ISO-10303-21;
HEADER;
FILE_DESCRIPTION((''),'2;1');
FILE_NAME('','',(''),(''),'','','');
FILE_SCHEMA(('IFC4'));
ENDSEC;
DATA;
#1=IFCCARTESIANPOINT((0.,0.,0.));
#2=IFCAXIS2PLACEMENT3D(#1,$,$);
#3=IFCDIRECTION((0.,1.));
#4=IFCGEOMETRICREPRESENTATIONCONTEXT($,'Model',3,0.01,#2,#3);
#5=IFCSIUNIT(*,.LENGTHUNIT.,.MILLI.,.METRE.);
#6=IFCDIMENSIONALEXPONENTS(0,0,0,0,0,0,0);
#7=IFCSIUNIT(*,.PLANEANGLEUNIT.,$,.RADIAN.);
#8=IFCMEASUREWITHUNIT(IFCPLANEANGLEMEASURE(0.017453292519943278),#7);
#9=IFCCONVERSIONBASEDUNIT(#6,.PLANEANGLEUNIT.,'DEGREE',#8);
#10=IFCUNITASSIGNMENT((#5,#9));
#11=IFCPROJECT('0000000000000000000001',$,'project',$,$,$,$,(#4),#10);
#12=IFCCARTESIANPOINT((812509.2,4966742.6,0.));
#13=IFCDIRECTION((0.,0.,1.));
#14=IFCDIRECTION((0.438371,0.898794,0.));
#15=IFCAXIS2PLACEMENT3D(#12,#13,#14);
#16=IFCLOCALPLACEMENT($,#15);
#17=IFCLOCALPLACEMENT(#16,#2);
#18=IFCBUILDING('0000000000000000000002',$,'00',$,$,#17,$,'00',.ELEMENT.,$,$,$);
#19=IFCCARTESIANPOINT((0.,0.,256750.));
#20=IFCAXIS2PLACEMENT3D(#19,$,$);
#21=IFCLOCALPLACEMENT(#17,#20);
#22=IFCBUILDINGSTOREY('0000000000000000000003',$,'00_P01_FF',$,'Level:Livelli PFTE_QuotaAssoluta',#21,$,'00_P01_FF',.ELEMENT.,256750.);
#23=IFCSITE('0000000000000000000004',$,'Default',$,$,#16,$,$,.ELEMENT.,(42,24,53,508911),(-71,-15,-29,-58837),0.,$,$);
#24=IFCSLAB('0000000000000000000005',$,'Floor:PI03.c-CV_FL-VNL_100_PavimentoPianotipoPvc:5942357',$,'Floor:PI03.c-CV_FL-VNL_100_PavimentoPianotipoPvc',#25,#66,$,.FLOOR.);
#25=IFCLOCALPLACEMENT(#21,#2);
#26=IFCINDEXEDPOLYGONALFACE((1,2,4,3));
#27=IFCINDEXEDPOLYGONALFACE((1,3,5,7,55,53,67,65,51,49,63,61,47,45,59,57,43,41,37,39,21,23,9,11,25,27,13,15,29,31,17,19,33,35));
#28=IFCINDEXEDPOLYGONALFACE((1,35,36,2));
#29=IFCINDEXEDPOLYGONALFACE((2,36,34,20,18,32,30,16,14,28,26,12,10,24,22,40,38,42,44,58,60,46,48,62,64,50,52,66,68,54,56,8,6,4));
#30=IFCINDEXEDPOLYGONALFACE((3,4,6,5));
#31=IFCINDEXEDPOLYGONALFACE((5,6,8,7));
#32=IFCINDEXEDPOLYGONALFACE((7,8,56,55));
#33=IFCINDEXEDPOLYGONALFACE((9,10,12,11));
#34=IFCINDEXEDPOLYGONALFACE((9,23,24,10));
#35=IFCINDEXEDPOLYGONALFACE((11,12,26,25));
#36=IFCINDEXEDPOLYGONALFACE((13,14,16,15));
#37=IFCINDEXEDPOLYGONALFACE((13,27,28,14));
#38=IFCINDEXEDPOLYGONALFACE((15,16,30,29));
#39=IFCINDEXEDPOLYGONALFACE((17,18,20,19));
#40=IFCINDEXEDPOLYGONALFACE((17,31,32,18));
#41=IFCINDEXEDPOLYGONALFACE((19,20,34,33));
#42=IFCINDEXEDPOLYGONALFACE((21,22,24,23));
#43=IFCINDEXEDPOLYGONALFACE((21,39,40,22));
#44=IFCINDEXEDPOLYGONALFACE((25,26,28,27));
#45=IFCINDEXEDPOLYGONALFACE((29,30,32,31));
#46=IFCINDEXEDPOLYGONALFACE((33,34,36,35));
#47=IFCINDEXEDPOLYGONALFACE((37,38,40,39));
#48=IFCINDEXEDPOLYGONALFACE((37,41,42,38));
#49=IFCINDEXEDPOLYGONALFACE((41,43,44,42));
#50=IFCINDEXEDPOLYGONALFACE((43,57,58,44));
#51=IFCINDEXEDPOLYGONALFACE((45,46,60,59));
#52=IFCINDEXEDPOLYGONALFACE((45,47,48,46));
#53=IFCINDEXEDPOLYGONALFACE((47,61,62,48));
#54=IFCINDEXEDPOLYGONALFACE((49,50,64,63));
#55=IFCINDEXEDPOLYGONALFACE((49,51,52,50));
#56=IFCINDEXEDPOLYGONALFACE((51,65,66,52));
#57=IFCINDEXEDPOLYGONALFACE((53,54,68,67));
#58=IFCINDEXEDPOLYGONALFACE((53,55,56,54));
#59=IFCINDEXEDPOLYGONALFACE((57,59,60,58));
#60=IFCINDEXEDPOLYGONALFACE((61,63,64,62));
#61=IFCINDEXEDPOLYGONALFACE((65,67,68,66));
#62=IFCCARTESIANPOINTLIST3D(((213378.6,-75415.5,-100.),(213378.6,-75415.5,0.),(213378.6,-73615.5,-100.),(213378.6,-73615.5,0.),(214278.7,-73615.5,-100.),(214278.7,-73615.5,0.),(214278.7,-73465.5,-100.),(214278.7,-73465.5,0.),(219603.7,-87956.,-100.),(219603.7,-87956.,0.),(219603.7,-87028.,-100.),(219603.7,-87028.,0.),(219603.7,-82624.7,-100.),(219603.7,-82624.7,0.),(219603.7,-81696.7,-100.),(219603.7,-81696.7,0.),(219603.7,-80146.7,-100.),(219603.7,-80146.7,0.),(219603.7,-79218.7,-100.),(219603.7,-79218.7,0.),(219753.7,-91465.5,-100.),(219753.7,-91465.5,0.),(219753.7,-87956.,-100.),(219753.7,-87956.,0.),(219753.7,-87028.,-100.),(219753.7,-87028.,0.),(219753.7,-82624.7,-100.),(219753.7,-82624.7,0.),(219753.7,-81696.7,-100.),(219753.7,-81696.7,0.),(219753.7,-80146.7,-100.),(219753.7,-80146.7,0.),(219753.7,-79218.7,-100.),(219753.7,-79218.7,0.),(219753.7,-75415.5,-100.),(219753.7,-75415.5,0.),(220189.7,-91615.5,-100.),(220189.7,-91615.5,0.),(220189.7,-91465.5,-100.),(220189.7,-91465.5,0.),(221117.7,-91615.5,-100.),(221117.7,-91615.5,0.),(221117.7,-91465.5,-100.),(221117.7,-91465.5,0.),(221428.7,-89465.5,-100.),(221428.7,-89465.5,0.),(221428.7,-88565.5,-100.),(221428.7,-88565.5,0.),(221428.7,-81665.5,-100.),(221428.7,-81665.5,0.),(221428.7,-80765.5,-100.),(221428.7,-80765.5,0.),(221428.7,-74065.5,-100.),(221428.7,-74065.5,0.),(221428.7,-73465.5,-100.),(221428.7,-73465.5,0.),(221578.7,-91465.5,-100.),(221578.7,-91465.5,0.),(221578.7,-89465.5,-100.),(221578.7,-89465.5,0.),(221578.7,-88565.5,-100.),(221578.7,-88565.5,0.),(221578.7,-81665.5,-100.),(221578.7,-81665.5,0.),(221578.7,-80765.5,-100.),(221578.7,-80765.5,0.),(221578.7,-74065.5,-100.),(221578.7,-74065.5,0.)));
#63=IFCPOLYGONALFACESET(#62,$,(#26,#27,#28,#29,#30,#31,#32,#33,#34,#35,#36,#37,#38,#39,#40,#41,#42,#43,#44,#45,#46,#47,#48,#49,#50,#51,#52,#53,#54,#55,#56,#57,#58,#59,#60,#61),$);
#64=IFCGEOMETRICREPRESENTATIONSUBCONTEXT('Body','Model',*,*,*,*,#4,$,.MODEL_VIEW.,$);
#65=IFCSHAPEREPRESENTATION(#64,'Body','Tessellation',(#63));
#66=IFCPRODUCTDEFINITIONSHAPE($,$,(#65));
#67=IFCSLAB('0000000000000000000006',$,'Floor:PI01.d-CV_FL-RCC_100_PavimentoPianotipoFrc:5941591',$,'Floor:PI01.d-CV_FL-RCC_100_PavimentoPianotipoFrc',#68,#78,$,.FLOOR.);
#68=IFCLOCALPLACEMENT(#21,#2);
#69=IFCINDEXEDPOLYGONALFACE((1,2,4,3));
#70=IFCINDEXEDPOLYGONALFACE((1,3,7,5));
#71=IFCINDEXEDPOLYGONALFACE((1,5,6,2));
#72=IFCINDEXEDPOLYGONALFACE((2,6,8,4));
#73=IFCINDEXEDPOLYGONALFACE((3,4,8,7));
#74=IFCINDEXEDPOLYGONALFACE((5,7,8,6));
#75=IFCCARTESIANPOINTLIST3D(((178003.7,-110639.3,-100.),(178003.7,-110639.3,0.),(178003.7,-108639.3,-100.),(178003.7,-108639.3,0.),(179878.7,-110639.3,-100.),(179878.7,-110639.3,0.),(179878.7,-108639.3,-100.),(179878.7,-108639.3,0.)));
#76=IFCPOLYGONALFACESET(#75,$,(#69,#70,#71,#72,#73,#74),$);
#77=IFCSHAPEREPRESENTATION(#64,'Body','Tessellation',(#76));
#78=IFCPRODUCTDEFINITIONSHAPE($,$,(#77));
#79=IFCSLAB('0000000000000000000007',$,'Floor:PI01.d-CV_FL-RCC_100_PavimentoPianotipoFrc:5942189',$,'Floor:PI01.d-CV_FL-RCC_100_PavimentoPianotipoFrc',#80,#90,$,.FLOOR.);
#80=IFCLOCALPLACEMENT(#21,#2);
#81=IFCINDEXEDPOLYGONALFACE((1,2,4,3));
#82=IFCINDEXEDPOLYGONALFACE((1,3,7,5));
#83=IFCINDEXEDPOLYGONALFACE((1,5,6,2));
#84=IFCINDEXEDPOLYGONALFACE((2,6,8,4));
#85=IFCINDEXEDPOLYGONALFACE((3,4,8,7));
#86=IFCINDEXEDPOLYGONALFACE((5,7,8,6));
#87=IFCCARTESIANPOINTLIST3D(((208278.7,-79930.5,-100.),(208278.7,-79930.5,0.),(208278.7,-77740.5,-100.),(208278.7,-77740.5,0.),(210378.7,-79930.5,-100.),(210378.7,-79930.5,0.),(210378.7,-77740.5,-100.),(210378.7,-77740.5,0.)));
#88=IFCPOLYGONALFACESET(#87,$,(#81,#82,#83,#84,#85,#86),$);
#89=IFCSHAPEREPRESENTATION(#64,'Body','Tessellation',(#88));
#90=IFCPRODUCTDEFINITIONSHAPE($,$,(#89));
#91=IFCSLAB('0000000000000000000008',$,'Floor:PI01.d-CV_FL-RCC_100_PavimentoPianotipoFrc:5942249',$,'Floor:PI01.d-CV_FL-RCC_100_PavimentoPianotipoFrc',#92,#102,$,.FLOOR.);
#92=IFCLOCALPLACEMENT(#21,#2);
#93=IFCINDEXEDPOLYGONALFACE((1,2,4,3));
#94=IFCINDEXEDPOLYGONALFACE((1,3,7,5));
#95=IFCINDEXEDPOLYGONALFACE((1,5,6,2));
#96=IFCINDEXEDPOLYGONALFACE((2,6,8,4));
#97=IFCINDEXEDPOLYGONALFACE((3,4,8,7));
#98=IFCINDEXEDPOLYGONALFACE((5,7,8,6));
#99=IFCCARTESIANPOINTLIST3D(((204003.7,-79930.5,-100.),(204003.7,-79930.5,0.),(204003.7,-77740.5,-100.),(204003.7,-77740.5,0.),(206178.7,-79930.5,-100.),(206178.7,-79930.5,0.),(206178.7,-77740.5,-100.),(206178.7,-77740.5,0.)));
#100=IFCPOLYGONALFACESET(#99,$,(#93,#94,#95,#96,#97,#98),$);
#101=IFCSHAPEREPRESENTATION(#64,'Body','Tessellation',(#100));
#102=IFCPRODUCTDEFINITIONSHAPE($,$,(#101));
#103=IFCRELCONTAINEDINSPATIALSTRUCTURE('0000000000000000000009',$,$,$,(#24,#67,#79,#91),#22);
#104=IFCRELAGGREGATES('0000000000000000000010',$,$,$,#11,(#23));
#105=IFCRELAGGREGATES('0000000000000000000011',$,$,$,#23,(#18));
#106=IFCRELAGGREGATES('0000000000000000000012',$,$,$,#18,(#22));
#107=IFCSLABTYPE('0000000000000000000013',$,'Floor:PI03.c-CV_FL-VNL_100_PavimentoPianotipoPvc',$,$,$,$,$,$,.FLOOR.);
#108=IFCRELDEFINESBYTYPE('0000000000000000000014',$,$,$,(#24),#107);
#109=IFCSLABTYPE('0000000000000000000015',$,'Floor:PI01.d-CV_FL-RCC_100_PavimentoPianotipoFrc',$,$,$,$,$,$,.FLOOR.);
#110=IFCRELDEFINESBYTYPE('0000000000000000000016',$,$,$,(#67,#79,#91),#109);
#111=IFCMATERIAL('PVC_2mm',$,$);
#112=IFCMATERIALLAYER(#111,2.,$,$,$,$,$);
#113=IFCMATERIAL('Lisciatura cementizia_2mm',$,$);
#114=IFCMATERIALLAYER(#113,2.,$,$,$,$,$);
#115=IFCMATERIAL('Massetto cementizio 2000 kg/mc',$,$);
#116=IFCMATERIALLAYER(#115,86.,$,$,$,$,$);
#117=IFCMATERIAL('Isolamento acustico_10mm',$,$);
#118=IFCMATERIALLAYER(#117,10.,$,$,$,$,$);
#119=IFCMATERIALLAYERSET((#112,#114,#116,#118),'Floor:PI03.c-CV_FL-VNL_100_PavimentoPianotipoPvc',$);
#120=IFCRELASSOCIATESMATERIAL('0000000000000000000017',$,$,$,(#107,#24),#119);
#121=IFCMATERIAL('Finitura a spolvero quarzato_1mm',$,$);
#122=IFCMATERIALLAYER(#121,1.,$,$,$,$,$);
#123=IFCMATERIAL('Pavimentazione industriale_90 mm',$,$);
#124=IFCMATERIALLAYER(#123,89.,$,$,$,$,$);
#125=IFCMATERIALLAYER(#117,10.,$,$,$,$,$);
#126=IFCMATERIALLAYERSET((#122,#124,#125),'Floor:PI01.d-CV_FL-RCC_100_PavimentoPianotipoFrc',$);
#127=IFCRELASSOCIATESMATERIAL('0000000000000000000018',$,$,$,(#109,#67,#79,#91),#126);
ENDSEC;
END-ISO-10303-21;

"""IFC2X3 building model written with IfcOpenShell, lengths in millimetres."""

from ifc_helpers import new_model, entity, si_unit, converted_unit, direction, frame, frame_2d, origin, place, context, subcontext, project, spatial, polyline, rectangle, outline, extrude, material, layer, layer_set, layer_usage, type_object, element, save


model = new_model("IFC2X3")

# Units and contexts
model_context = context("Model", 3, precision=0.01, world=origin(), true_north=direction((0.0, 1.0)))
body_context = subcontext(model_context, "Body", "Model", "MODEL_VIEW")
ifc_project = project(units=[si_unit("LENGTHUNIT", "METRE", prefix="MILLI"), converted_unit("PLANEANGLEUNIT", "DEGREE", entity("IfcPlaneAngleMeasure", 0.017453292519943278), si_unit("PLANEANGLEUNIT", "RADIAN"), dimensions=[0, 0, 0, 0, 0, 0, 0])], contexts=[model_context])

# Site, building, storey
site_placement = place(None, frame((812509.2, 4966742.6, 0.0), z_axis=(0.0, 0.0, 1.0), x_axis=(0.438371, 0.898794, 0.0)))
site = spatial("IfcSite", under=ifc_project, at=site_placement, Name="Default", CompositionType="ELEMENT", RefLatitude=(42, 24, 53, 508911), RefLongitude=(-71, -15, -29, -58837), RefElevation=0.0)
building_placement = place(site_placement, origin())
building = spatial("IfcBuilding", under=site, at=building_placement, Name="00", LongName="00", CompositionType="ELEMENT")
storey_placement = place(building_placement, frame((0.0, 0.0, 256750.0)))
storey = spatial("IfcBuildingStorey", under=building, at=storey_placement, Name="00_P01_FF", ObjectType="Level:Livelli PFTE_QuotaAssoluta", LongName="00_P01_FF", CompositionType="ELEMENT", Elevation=256750.0)

# Slabs
ifc_material_1 = material(Name="PVC_2mm")
ifc_layer_1 = layer(ifc_material_1, 2.0)
ifc_material_2 = material(Name="Lisciatura cementizia_2mm")
ifc_layer_2 = layer(ifc_material_2, 2.0)
ifc_material_3 = material(Name="Massetto cementizio 2000 kg/mc")
ifc_layer_3 = layer(ifc_material_3, 86.0)
ifc_material_4 = material(Name="Isolamento acustico_10mm")
ifc_layer_4 = layer(ifc_material_4, 10.0)
ifc_layer_set_1 = layer_set([ifc_layer_1, ifc_layer_2, ifc_layer_3, ifc_layer_4], Name="Floor:PI03.c-CV_FL-VNL_100_PavimentoPianotipoPvc")
slab_type_1 = type_object("IfcSlabType", Name="Floor:PI03.c-CV_FL-VNL_100_PavimentoPianotipoPvc", PredefinedType="FLOOR", material=ifc_layer_set_1)
ifc_layer_usage_1 = layer_usage(ifc_layer_set_1, "AXIS3", "POSITIVE", 0.0)
slab_1_placement = place(storey_placement, origin())
element("IfcSlab", 1, at=slab_1_placement, inside=storey, type_object=slab_type_1, material=ifc_layer_usage_1, Name="Floor:PI03.c-CV_FL-VNL_100_PavimentoPianotipoPvc:5942357", ObjectType="Floor:PI03.c-CV_FL-VNL_100_PavimentoPianotipoPvc", PredefinedType="FLOOR", context=body_context, shape_type="SweptSolid", body=[
    extrude(outline(polyline([(7539.9, -6375.0), (9339.9, -6375.0), (9339.9, -5475.0), (9489.9, -5475.0), (9489.9, 1675.0), (8889.9, 1675.0), (8889.9, 1825.0), (2189.9, 1825.0), (2189.9, 1675.0), (1289.9, 1675.0), (1289.9, 1825.0), (-5610.1, 1825.0), (-5610.1, 1675.0), (-6510.1, 1675.0), (-6510.1, 1825.0), (-8510.1, 1825.0), (-8510.1, 1364.0), (-8660.1, 1364.0), (-8660.1, 436.0), (-8510.1, 436.0), (-8510.1, 0.0), (-5000.6, 0.0), (-5000.6, -150.0), (-4072.6, -150.0), (-4072.6, 0.0), (330.6, 0.0), (330.6, -150.0), (1258.6, -150.0), (1258.6, 0.0), (2808.6, 0.0), (2808.6, -150.0), (3736.6, -150.0), (3736.6, 0.0), (7539.9, 0.0), (7539.9, -6375.0)])), frame((219753.7, -82955.4, 0.0), z_axis=(0.0, 0.0, -1.0), x_axis=(0.0, 1.0, 0.0)), (0.0, 0.0, 1.0), 100.0),
])
ifc_material_5 = material(Name="Finitura a spolvero quarzato_1mm")
ifc_layer_5 = layer(ifc_material_5, 1.0)
ifc_material_6 = material(Name="Pavimentazione industriale_90 mm")
ifc_layer_6 = layer(ifc_material_6, 89.0)
ifc_layer_7 = layer(ifc_material_4, 10.0)
ifc_layer_set_2 = layer_set([ifc_layer_5, ifc_layer_6, ifc_layer_7], Name="Floor:PI01.d-CV_FL-RCC_100_PavimentoPianotipoFrc")
ifc_layer_usage_2 = layer_usage(ifc_layer_set_2, "AXIS3", "POSITIVE", 0.0)
slab_type_2 = type_object("IfcSlabType", Name="Floor:PI01.d-CV_FL-RCC_100_PavimentoPianotipoFrc", PredefinedType="FLOOR", material=ifc_layer_set_2)
slab_2_placement = place(storey_placement, origin())
element("IfcSlab", 2, at=slab_2_placement, inside=storey, type_object=slab_type_2, material=ifc_layer_usage_2, Name="Floor:PI01.d-CV_FL-RCC_100_PavimentoPianotipoFrc:5941591", ObjectType="Floor:PI01.d-CV_FL-RCC_100_PavimentoPianotipoFrc", PredefinedType="FLOOR", context=body_context, shape_type="SweptSolid", body=[
    extrude(rectangle(XDim=2000.0, YDim=1875.0, at=frame_2d((0.0, 0.0), x_axis=(1.0, 0.0))), frame((178941.2, -109639.3, 0.0), z_axis=(0.0, 0.0, -1.0), x_axis=(0.0, 1.0, 0.0)), (0.0, 0.0, 1.0), 100.0),
])
ifc_layer_usage_3 = layer_usage(ifc_layer_set_2, "AXIS3", "POSITIVE", 0.0)
slab_3_placement = place(storey_placement, origin())
element("IfcSlab", 3, at=slab_3_placement, inside=storey, type_object=slab_type_2, material=ifc_layer_usage_3, Name="Floor:PI01.d-CV_FL-RCC_100_PavimentoPianotipoFrc:5942189", ObjectType="Floor:PI01.d-CV_FL-RCC_100_PavimentoPianotipoFrc", PredefinedType="FLOOR", context=body_context, shape_type="SweptSolid", body=[
    extrude(rectangle(XDim=2190.0, YDim=2100.0, at=frame_2d((0.0, 0.0), x_axis=(1.0, 0.0))), frame((209328.7, -78835.5, 0.0), z_axis=(0.0, 0.0, -1.0), x_axis=(0.0, 1.0, 0.0)), (0.0, 0.0, 1.0), 100.0),
])
ifc_layer_usage_4 = layer_usage(ifc_layer_set_2, "AXIS3", "POSITIVE", 0.0)
slab_4_placement = place(storey_placement, origin())
element("IfcSlab", 4, at=slab_4_placement, inside=storey, type_object=slab_type_2, material=ifc_layer_usage_4, Name="Floor:PI01.d-CV_FL-RCC_100_PavimentoPianotipoFrc:5942249", ObjectType="Floor:PI01.d-CV_FL-RCC_100_PavimentoPianotipoFrc", PredefinedType="FLOOR", context=body_context, shape_type="SweptSolid", body=[
    extrude(rectangle(XDim=2190.0, YDim=2175.0, at=frame_2d((0.0, 0.0), x_axis=(1.0, 0.0))), frame((205091.2, -78835.5, 0.0), z_axis=(0.0, 0.0, -1.0), x_axis=(0.0, 1.0, 0.0)), (0.0, 0.0, 1.0), 100.0),
])

save(model, "model.ifc")
